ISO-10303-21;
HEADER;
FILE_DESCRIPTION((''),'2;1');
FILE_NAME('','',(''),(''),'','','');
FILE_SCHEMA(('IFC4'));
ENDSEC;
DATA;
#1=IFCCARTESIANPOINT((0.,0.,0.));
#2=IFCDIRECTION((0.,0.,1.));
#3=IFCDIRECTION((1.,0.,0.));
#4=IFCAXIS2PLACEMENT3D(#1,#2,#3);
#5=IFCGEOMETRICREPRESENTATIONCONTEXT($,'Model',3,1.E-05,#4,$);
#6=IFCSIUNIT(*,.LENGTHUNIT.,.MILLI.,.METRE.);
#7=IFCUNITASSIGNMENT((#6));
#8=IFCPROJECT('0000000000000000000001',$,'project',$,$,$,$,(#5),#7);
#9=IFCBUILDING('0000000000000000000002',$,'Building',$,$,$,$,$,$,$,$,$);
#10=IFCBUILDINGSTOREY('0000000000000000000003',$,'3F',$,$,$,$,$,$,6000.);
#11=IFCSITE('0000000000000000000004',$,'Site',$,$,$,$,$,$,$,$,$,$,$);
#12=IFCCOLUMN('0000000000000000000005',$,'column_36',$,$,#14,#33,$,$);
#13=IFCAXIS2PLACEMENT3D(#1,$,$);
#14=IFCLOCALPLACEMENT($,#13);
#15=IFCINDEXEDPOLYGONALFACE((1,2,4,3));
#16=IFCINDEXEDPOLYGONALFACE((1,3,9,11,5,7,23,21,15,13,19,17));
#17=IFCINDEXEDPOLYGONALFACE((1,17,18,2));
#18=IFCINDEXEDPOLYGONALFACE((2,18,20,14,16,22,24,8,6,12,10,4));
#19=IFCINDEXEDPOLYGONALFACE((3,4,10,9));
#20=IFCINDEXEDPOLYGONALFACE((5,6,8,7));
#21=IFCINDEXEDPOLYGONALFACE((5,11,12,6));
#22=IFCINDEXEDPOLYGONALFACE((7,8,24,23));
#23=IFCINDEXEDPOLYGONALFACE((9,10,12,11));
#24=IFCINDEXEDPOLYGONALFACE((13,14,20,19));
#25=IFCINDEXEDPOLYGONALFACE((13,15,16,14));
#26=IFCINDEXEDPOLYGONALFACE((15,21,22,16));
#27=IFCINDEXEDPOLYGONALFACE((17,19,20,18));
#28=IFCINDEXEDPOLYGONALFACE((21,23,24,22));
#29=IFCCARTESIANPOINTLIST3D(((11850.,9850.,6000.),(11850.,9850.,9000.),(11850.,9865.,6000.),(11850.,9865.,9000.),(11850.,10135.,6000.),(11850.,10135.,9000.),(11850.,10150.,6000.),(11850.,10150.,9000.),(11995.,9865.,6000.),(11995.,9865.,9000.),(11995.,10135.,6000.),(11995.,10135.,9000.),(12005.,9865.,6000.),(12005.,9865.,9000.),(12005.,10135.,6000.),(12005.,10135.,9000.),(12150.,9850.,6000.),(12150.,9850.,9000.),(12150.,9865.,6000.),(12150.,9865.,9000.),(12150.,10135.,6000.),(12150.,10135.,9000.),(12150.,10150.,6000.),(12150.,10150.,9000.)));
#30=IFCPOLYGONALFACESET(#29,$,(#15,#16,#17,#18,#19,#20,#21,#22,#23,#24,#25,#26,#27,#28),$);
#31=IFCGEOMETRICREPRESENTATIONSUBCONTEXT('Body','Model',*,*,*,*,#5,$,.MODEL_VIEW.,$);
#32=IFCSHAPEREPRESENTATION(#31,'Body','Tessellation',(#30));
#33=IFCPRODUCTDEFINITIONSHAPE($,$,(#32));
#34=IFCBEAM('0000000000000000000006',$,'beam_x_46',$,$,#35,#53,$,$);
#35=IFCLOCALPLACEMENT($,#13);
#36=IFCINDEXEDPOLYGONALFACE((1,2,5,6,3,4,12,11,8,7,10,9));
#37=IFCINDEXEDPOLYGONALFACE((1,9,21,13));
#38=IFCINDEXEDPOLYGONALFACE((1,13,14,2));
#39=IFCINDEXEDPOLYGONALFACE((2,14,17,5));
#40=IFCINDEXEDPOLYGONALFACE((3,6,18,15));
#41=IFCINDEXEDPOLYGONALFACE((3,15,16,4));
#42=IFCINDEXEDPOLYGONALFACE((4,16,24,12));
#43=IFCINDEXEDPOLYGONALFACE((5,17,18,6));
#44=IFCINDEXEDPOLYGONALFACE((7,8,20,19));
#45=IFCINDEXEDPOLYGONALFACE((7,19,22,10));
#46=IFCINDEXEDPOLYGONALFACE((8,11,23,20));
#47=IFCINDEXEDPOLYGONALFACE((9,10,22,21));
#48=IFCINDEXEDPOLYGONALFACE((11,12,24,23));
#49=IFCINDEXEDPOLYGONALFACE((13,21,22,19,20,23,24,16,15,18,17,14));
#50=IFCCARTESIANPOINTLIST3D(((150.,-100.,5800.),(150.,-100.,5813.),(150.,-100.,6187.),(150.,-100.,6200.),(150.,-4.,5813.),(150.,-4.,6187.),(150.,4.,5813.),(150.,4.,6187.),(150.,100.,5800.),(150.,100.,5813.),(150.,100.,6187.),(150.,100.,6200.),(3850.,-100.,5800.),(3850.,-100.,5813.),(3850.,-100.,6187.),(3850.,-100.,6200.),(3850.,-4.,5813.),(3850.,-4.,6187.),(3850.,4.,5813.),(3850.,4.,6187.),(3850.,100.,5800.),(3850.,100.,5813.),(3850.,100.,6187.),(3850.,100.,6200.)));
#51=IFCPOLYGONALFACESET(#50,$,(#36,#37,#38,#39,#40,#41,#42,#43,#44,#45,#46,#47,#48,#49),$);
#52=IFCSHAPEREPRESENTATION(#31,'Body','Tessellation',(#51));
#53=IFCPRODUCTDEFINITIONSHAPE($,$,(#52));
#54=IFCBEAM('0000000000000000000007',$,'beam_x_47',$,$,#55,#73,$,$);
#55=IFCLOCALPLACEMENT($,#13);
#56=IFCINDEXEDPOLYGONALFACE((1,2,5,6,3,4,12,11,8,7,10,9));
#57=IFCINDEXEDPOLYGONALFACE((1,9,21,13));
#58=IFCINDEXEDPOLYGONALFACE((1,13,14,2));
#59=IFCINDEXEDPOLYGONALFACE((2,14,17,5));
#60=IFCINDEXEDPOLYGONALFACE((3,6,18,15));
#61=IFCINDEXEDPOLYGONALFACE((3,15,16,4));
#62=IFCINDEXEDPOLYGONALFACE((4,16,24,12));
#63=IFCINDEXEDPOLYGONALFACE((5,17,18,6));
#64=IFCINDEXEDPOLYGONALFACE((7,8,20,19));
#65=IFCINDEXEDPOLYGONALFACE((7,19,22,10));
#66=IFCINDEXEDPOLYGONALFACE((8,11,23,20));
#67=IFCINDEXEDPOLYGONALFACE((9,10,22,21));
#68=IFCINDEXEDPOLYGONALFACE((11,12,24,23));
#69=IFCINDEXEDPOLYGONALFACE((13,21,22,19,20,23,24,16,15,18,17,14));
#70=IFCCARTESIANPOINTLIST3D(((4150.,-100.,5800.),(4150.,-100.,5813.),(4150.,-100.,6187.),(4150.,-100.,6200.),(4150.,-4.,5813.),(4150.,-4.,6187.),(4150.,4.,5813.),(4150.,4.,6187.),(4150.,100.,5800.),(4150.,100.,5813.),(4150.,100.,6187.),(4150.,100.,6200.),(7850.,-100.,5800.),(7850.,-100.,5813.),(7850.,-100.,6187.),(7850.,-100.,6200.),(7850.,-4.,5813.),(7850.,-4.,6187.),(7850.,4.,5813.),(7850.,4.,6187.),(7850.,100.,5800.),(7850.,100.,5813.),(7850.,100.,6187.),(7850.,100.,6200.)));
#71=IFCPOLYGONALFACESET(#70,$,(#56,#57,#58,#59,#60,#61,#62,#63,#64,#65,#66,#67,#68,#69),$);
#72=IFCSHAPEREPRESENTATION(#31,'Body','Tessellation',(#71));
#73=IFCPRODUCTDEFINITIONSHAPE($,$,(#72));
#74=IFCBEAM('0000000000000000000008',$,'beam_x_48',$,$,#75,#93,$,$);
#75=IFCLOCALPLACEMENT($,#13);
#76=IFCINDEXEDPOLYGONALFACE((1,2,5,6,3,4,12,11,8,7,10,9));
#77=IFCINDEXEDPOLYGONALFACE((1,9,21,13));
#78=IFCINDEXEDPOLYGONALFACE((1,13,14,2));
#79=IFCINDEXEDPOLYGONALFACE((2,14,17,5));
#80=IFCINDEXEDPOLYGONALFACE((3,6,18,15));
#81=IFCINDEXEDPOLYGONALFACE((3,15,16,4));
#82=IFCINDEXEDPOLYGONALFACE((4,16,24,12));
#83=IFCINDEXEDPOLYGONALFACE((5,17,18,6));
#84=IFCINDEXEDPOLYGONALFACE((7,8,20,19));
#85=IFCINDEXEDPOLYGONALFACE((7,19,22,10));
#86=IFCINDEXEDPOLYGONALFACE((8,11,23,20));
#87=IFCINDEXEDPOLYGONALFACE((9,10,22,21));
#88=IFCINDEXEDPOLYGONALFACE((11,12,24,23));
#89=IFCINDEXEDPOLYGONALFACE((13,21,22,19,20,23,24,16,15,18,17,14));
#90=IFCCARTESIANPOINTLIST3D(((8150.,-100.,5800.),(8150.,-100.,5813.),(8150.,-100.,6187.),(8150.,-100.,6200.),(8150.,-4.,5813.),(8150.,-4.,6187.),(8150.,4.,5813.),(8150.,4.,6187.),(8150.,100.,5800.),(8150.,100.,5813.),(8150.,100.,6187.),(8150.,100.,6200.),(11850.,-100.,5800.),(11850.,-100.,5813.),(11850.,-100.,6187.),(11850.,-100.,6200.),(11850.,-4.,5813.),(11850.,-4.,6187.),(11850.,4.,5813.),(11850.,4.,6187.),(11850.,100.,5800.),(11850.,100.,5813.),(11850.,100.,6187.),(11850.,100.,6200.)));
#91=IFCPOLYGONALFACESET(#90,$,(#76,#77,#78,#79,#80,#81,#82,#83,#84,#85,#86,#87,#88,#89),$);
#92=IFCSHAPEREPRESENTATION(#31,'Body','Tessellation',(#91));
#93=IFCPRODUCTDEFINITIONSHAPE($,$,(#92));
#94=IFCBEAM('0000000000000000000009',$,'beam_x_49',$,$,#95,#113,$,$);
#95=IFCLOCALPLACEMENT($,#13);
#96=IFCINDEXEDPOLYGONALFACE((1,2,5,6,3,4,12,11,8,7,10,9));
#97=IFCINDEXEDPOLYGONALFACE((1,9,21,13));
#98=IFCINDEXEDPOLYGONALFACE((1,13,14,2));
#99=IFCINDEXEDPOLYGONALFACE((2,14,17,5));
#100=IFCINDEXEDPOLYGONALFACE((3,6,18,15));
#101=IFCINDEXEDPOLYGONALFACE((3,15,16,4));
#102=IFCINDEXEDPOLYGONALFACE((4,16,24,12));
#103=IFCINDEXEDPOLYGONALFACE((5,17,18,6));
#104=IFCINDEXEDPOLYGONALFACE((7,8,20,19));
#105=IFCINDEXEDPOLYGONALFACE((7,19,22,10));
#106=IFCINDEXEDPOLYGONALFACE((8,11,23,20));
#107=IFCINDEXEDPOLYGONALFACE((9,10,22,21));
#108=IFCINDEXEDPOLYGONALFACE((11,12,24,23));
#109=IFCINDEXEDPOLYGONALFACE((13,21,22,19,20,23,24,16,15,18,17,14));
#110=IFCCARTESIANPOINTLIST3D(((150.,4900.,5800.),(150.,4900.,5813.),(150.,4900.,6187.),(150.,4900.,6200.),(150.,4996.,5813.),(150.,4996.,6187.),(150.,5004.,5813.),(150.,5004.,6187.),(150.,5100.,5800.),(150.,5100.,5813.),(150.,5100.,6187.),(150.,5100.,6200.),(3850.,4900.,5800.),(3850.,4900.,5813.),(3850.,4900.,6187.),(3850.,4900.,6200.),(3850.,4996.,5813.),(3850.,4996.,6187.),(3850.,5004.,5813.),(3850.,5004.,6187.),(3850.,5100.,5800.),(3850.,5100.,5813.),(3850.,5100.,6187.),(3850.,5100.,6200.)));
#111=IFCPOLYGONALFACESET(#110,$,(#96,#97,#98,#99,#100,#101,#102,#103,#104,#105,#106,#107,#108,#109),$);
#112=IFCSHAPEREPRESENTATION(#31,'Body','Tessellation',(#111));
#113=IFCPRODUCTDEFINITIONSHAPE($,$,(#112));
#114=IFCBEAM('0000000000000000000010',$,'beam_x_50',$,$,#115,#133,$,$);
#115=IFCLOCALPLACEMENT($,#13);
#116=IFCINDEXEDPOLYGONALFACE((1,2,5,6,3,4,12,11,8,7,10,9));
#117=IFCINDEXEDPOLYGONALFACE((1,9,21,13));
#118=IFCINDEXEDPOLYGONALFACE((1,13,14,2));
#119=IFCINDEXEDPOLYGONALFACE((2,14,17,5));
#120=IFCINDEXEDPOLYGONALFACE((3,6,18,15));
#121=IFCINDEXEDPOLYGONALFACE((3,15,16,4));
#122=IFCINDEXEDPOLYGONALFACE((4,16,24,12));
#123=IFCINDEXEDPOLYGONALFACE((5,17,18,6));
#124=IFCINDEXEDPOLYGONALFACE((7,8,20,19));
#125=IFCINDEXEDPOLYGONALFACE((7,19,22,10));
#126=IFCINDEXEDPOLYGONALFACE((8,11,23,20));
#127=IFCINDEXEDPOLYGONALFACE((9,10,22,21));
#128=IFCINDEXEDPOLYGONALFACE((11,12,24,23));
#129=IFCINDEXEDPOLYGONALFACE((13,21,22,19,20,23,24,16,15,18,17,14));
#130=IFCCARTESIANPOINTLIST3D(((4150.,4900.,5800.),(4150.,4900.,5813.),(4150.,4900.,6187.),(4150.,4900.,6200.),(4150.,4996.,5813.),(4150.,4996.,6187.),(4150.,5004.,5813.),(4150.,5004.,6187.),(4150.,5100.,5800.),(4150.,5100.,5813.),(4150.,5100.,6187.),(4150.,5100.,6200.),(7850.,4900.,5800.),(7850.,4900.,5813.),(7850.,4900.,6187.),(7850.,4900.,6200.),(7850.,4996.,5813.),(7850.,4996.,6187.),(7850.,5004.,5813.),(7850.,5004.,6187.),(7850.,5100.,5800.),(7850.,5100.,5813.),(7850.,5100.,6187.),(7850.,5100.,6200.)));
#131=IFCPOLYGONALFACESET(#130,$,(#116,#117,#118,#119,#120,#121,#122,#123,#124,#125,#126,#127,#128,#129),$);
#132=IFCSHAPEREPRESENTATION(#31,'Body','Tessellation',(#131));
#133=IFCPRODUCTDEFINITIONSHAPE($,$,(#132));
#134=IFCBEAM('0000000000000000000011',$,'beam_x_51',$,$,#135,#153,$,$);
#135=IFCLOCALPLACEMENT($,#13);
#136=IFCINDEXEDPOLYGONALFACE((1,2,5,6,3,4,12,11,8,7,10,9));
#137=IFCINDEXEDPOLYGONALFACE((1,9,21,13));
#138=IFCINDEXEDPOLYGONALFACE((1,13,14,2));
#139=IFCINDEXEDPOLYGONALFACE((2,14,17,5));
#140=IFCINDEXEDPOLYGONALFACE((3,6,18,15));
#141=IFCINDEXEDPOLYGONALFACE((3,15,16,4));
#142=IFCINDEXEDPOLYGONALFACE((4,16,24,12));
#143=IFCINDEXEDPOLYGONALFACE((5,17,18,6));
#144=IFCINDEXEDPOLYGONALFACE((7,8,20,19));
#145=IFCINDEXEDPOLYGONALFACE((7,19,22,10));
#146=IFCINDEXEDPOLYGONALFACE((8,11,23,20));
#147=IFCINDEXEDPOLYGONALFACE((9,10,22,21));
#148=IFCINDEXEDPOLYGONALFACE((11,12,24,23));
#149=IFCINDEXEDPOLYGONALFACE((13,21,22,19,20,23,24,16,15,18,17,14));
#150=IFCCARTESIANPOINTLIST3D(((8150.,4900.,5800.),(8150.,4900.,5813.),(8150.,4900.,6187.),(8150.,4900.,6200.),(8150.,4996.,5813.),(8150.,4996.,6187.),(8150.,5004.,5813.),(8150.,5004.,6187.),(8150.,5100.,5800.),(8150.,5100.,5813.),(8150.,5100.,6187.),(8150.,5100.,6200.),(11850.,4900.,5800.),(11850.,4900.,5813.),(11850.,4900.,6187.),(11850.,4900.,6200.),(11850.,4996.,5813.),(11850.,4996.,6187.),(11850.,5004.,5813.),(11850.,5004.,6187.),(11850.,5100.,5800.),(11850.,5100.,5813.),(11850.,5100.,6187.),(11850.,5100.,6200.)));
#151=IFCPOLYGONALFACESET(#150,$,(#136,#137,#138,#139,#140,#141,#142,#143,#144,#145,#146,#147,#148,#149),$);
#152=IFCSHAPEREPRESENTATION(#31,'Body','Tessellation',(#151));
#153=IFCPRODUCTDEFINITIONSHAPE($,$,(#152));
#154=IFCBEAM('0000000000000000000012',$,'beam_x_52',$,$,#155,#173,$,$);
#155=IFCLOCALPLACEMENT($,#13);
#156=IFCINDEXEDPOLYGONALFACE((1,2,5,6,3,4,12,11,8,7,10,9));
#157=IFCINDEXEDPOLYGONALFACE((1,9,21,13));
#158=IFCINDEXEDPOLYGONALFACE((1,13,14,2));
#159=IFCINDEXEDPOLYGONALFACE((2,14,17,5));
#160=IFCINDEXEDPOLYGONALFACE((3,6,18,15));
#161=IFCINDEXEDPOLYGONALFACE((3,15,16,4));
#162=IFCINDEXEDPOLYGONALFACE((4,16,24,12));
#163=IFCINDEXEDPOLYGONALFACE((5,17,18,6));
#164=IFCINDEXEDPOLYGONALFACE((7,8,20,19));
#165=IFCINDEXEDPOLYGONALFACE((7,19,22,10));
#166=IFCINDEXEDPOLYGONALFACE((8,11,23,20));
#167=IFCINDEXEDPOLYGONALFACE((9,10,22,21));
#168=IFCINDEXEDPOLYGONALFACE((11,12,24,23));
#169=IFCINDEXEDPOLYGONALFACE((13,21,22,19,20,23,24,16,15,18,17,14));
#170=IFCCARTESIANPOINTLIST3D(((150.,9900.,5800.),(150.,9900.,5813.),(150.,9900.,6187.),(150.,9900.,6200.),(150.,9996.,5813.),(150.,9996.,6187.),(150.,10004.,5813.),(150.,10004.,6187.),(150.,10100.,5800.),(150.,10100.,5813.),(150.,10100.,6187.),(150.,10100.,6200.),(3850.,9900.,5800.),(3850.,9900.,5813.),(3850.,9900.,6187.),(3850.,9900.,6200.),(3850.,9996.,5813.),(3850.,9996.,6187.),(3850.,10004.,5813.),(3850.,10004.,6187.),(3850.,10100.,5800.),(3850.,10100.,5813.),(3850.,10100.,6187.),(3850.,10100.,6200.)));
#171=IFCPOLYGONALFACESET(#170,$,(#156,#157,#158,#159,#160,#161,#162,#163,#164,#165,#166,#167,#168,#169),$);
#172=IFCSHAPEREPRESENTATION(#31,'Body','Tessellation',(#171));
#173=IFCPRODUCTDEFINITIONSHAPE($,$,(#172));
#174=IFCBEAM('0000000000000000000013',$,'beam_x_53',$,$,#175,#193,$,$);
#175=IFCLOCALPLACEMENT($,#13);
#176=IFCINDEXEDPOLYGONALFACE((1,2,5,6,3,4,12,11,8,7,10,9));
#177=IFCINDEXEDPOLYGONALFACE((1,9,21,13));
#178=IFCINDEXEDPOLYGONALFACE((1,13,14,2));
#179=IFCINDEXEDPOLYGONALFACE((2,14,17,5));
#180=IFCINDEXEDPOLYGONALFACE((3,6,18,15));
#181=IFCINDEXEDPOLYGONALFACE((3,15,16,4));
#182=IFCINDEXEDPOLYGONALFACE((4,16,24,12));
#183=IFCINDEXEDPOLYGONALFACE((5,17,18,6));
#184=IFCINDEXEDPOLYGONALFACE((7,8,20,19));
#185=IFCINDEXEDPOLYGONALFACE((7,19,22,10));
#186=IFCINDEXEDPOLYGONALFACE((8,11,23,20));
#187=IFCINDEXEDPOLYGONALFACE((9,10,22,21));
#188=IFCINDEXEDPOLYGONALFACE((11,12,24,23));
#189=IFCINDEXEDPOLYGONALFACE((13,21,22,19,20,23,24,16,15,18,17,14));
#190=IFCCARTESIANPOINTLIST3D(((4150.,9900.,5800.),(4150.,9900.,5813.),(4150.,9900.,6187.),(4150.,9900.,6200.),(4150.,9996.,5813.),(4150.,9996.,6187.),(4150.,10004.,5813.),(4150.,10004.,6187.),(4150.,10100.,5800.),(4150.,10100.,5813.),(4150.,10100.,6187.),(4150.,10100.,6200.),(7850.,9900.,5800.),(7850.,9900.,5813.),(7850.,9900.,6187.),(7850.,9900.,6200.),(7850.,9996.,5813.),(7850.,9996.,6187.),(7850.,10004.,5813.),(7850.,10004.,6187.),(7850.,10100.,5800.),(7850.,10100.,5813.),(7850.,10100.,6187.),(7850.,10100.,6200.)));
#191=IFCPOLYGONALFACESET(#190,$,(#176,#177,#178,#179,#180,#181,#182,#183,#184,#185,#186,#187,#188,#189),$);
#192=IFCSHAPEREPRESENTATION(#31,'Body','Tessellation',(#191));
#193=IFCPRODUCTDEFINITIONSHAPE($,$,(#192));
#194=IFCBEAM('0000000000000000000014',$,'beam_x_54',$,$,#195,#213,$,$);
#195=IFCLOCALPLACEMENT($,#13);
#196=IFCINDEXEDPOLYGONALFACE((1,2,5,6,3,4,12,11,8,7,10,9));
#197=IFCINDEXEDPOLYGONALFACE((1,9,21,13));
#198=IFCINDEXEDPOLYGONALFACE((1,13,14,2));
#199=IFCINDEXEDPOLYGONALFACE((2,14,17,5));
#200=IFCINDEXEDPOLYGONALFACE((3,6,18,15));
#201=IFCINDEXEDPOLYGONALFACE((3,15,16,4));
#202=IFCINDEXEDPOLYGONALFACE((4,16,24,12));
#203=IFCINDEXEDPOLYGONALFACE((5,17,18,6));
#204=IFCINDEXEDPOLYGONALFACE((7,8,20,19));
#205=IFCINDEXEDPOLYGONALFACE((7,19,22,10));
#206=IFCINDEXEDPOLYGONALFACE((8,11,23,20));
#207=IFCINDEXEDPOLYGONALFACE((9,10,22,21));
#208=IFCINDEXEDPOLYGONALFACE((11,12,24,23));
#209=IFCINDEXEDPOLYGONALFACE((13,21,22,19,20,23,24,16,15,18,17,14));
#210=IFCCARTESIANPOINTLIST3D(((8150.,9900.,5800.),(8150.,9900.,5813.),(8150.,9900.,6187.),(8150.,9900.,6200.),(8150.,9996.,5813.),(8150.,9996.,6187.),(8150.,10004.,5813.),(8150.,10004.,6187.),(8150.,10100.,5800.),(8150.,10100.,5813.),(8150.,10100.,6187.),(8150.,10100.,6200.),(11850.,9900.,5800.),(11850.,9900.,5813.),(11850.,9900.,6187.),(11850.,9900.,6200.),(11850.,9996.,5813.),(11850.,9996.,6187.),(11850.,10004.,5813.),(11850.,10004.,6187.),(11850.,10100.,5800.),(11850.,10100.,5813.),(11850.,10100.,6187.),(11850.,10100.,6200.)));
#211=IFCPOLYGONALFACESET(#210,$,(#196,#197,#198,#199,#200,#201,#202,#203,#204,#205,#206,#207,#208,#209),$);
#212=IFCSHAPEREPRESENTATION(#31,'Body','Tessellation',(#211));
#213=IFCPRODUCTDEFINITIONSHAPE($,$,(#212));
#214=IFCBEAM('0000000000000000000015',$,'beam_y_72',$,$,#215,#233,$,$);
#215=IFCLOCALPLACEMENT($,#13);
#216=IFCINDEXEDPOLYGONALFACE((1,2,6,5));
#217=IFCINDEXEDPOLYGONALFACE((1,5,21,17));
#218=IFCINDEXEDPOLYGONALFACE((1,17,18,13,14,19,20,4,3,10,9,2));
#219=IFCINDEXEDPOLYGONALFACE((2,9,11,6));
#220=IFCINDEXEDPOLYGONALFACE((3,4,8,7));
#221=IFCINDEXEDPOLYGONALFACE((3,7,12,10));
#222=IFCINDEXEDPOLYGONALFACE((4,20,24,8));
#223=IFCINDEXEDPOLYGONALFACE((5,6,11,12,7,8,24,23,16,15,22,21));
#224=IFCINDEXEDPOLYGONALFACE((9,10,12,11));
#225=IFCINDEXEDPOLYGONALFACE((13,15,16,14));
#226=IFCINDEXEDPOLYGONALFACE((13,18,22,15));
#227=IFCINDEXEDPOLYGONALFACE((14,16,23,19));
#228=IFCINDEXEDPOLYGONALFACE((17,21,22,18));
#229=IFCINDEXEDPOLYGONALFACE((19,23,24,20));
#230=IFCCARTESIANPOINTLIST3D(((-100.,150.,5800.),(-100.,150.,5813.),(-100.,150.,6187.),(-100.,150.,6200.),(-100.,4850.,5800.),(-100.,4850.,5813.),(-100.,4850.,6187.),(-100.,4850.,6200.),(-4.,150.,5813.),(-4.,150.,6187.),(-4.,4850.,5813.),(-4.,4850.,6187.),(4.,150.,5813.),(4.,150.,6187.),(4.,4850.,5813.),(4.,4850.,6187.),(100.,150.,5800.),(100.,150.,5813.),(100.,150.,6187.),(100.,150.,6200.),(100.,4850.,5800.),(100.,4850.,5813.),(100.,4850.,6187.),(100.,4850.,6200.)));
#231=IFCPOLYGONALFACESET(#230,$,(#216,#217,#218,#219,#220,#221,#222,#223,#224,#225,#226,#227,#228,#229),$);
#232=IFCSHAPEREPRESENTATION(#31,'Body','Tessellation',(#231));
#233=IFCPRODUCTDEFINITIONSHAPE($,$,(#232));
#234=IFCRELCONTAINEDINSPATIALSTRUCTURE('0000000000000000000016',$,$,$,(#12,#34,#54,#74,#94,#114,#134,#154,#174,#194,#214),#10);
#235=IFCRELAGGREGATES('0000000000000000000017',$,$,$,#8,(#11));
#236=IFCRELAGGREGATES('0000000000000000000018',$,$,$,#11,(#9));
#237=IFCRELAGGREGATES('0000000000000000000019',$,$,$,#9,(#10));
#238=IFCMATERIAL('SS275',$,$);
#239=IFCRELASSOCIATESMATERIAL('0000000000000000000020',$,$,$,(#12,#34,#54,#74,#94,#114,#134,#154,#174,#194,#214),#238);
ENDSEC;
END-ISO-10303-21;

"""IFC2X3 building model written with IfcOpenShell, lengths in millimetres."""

from ifc_helpers import new_model, si_unit, frame, origin, origin_with_axes, origin_2d_with_axis, place, context, subcontext, project, spatial, i_section, extrude, material, element, save


model = new_model("IFC2X3")

# Units and contexts
model_context = context("Model", 3, precision=1e-05, world=origin_with_axes())
body_context = subcontext(model_context, "Body", "Model", "MODEL_VIEW")
ifc_project = project(units=[si_unit("LENGTHUNIT", "METRE", prefix="MILLI")], contexts=[model_context])

# Site, building, storey
site = spatial("IfcSite", under=ifc_project, Name="Site")
building = spatial("IfcBuilding", under=site, Name="Building")
storey = spatial("IfcBuildingStorey", under=building, Name="3F", Elevation=6000.0)

# Column
ifc_material = material(Name="SS275")
for number, where, z_axis, x_axis, name in (
    (1, (12000.0, 10000.0, 6000.0), (0.0, 0.0, 1.0), (1.0, 0.0, 0.0), "column_36"),
):
    element("IfcColumn", number, at=place(None, frame(where, z_axis=z_axis, x_axis=x_axis)), inside=storey, material=ifc_material, Name=name, context=body_context, shape_type="SweptSolid", body=[
        extrude(i_section(OverallWidth=300.0, OverallDepth=300.0, WebThickness=10.0, FlangeThickness=15.0, at=origin_2d_with_axis()), origin(), (0.0, 0.0, 1.0), 3000.0),
    ])

# Beams
for number, where, z_axis, x_axis, name in (
    (2, (150.0, 0.0, 6000.0), (1.0, 0.0, 0.0), (0.0, 1.0, 0.0), "beam_x_46"),
    (3, (4150.0, 0.0, 6000.0), (1.0, 0.0, 0.0), (0.0, 1.0, 0.0), "beam_x_47"),
    (4, (8150.0, 0.0, 6000.0), (1.0, 0.0, 0.0), (0.0, 1.0, 0.0), "beam_x_48"),
    (5, (150.0, 5000.0, 6000.0), (1.0, 0.0, 0.0), (0.0, 1.0, 0.0), "beam_x_49"),
    (6, (4150.0, 5000.0, 6000.0), (1.0, 0.0, 0.0), (0.0, 1.0, 0.0), "beam_x_50"),
    (7, (8150.0, 5000.0, 6000.0), (1.0, 0.0, 0.0), (0.0, 1.0, 0.0), "beam_x_51"),
    (8, (150.0, 10000.0, 6000.0), (1.0, 0.0, 0.0), (0.0, 1.0, 0.0), "beam_x_52"),
    (9, (4150.0, 10000.0, 6000.0), (1.0, 0.0, 0.0), (0.0, 1.0, 0.0), "beam_x_53"),
    (10, (8150.0, 10000.0, 6000.0), (1.0, 0.0, 0.0), (0.0, 1.0, 0.0), "beam_x_54"),
):
    element("IfcBeam", number, at=place(None, frame(where, z_axis=z_axis, x_axis=x_axis)), inside=storey, material=ifc_material, Name=name, context=body_context, shape_type="SweptSolid", body=[
        extrude(i_section(OverallWidth=200.0, OverallDepth=400.0, WebThickness=8.0, FlangeThickness=13.0, at=origin_2d_with_axis()), origin(), (0.0, 0.0, 1.0), 3700.0),
    ])
for number, where, z_axis, x_axis, name in (
    (11, (0.0, 150.0, 6000.0), (0.0, 1.0, 0.0), (-1.0, 0.0, 0.0), "beam_y_72"),
):
    element("IfcBeam", number, at=place(None, frame(where, z_axis=z_axis, x_axis=x_axis)), inside=storey, material=ifc_material, Name=name, context=body_context, shape_type="SweptSolid", body=[
        extrude(i_section(OverallWidth=200.0, OverallDepth=400.0, WebThickness=8.0, FlangeThickness=13.0, at=origin_2d_with_axis()), origin(), (0.0, 0.0, 1.0), 4700.0),
    ])

save(model, "model.ifc")
